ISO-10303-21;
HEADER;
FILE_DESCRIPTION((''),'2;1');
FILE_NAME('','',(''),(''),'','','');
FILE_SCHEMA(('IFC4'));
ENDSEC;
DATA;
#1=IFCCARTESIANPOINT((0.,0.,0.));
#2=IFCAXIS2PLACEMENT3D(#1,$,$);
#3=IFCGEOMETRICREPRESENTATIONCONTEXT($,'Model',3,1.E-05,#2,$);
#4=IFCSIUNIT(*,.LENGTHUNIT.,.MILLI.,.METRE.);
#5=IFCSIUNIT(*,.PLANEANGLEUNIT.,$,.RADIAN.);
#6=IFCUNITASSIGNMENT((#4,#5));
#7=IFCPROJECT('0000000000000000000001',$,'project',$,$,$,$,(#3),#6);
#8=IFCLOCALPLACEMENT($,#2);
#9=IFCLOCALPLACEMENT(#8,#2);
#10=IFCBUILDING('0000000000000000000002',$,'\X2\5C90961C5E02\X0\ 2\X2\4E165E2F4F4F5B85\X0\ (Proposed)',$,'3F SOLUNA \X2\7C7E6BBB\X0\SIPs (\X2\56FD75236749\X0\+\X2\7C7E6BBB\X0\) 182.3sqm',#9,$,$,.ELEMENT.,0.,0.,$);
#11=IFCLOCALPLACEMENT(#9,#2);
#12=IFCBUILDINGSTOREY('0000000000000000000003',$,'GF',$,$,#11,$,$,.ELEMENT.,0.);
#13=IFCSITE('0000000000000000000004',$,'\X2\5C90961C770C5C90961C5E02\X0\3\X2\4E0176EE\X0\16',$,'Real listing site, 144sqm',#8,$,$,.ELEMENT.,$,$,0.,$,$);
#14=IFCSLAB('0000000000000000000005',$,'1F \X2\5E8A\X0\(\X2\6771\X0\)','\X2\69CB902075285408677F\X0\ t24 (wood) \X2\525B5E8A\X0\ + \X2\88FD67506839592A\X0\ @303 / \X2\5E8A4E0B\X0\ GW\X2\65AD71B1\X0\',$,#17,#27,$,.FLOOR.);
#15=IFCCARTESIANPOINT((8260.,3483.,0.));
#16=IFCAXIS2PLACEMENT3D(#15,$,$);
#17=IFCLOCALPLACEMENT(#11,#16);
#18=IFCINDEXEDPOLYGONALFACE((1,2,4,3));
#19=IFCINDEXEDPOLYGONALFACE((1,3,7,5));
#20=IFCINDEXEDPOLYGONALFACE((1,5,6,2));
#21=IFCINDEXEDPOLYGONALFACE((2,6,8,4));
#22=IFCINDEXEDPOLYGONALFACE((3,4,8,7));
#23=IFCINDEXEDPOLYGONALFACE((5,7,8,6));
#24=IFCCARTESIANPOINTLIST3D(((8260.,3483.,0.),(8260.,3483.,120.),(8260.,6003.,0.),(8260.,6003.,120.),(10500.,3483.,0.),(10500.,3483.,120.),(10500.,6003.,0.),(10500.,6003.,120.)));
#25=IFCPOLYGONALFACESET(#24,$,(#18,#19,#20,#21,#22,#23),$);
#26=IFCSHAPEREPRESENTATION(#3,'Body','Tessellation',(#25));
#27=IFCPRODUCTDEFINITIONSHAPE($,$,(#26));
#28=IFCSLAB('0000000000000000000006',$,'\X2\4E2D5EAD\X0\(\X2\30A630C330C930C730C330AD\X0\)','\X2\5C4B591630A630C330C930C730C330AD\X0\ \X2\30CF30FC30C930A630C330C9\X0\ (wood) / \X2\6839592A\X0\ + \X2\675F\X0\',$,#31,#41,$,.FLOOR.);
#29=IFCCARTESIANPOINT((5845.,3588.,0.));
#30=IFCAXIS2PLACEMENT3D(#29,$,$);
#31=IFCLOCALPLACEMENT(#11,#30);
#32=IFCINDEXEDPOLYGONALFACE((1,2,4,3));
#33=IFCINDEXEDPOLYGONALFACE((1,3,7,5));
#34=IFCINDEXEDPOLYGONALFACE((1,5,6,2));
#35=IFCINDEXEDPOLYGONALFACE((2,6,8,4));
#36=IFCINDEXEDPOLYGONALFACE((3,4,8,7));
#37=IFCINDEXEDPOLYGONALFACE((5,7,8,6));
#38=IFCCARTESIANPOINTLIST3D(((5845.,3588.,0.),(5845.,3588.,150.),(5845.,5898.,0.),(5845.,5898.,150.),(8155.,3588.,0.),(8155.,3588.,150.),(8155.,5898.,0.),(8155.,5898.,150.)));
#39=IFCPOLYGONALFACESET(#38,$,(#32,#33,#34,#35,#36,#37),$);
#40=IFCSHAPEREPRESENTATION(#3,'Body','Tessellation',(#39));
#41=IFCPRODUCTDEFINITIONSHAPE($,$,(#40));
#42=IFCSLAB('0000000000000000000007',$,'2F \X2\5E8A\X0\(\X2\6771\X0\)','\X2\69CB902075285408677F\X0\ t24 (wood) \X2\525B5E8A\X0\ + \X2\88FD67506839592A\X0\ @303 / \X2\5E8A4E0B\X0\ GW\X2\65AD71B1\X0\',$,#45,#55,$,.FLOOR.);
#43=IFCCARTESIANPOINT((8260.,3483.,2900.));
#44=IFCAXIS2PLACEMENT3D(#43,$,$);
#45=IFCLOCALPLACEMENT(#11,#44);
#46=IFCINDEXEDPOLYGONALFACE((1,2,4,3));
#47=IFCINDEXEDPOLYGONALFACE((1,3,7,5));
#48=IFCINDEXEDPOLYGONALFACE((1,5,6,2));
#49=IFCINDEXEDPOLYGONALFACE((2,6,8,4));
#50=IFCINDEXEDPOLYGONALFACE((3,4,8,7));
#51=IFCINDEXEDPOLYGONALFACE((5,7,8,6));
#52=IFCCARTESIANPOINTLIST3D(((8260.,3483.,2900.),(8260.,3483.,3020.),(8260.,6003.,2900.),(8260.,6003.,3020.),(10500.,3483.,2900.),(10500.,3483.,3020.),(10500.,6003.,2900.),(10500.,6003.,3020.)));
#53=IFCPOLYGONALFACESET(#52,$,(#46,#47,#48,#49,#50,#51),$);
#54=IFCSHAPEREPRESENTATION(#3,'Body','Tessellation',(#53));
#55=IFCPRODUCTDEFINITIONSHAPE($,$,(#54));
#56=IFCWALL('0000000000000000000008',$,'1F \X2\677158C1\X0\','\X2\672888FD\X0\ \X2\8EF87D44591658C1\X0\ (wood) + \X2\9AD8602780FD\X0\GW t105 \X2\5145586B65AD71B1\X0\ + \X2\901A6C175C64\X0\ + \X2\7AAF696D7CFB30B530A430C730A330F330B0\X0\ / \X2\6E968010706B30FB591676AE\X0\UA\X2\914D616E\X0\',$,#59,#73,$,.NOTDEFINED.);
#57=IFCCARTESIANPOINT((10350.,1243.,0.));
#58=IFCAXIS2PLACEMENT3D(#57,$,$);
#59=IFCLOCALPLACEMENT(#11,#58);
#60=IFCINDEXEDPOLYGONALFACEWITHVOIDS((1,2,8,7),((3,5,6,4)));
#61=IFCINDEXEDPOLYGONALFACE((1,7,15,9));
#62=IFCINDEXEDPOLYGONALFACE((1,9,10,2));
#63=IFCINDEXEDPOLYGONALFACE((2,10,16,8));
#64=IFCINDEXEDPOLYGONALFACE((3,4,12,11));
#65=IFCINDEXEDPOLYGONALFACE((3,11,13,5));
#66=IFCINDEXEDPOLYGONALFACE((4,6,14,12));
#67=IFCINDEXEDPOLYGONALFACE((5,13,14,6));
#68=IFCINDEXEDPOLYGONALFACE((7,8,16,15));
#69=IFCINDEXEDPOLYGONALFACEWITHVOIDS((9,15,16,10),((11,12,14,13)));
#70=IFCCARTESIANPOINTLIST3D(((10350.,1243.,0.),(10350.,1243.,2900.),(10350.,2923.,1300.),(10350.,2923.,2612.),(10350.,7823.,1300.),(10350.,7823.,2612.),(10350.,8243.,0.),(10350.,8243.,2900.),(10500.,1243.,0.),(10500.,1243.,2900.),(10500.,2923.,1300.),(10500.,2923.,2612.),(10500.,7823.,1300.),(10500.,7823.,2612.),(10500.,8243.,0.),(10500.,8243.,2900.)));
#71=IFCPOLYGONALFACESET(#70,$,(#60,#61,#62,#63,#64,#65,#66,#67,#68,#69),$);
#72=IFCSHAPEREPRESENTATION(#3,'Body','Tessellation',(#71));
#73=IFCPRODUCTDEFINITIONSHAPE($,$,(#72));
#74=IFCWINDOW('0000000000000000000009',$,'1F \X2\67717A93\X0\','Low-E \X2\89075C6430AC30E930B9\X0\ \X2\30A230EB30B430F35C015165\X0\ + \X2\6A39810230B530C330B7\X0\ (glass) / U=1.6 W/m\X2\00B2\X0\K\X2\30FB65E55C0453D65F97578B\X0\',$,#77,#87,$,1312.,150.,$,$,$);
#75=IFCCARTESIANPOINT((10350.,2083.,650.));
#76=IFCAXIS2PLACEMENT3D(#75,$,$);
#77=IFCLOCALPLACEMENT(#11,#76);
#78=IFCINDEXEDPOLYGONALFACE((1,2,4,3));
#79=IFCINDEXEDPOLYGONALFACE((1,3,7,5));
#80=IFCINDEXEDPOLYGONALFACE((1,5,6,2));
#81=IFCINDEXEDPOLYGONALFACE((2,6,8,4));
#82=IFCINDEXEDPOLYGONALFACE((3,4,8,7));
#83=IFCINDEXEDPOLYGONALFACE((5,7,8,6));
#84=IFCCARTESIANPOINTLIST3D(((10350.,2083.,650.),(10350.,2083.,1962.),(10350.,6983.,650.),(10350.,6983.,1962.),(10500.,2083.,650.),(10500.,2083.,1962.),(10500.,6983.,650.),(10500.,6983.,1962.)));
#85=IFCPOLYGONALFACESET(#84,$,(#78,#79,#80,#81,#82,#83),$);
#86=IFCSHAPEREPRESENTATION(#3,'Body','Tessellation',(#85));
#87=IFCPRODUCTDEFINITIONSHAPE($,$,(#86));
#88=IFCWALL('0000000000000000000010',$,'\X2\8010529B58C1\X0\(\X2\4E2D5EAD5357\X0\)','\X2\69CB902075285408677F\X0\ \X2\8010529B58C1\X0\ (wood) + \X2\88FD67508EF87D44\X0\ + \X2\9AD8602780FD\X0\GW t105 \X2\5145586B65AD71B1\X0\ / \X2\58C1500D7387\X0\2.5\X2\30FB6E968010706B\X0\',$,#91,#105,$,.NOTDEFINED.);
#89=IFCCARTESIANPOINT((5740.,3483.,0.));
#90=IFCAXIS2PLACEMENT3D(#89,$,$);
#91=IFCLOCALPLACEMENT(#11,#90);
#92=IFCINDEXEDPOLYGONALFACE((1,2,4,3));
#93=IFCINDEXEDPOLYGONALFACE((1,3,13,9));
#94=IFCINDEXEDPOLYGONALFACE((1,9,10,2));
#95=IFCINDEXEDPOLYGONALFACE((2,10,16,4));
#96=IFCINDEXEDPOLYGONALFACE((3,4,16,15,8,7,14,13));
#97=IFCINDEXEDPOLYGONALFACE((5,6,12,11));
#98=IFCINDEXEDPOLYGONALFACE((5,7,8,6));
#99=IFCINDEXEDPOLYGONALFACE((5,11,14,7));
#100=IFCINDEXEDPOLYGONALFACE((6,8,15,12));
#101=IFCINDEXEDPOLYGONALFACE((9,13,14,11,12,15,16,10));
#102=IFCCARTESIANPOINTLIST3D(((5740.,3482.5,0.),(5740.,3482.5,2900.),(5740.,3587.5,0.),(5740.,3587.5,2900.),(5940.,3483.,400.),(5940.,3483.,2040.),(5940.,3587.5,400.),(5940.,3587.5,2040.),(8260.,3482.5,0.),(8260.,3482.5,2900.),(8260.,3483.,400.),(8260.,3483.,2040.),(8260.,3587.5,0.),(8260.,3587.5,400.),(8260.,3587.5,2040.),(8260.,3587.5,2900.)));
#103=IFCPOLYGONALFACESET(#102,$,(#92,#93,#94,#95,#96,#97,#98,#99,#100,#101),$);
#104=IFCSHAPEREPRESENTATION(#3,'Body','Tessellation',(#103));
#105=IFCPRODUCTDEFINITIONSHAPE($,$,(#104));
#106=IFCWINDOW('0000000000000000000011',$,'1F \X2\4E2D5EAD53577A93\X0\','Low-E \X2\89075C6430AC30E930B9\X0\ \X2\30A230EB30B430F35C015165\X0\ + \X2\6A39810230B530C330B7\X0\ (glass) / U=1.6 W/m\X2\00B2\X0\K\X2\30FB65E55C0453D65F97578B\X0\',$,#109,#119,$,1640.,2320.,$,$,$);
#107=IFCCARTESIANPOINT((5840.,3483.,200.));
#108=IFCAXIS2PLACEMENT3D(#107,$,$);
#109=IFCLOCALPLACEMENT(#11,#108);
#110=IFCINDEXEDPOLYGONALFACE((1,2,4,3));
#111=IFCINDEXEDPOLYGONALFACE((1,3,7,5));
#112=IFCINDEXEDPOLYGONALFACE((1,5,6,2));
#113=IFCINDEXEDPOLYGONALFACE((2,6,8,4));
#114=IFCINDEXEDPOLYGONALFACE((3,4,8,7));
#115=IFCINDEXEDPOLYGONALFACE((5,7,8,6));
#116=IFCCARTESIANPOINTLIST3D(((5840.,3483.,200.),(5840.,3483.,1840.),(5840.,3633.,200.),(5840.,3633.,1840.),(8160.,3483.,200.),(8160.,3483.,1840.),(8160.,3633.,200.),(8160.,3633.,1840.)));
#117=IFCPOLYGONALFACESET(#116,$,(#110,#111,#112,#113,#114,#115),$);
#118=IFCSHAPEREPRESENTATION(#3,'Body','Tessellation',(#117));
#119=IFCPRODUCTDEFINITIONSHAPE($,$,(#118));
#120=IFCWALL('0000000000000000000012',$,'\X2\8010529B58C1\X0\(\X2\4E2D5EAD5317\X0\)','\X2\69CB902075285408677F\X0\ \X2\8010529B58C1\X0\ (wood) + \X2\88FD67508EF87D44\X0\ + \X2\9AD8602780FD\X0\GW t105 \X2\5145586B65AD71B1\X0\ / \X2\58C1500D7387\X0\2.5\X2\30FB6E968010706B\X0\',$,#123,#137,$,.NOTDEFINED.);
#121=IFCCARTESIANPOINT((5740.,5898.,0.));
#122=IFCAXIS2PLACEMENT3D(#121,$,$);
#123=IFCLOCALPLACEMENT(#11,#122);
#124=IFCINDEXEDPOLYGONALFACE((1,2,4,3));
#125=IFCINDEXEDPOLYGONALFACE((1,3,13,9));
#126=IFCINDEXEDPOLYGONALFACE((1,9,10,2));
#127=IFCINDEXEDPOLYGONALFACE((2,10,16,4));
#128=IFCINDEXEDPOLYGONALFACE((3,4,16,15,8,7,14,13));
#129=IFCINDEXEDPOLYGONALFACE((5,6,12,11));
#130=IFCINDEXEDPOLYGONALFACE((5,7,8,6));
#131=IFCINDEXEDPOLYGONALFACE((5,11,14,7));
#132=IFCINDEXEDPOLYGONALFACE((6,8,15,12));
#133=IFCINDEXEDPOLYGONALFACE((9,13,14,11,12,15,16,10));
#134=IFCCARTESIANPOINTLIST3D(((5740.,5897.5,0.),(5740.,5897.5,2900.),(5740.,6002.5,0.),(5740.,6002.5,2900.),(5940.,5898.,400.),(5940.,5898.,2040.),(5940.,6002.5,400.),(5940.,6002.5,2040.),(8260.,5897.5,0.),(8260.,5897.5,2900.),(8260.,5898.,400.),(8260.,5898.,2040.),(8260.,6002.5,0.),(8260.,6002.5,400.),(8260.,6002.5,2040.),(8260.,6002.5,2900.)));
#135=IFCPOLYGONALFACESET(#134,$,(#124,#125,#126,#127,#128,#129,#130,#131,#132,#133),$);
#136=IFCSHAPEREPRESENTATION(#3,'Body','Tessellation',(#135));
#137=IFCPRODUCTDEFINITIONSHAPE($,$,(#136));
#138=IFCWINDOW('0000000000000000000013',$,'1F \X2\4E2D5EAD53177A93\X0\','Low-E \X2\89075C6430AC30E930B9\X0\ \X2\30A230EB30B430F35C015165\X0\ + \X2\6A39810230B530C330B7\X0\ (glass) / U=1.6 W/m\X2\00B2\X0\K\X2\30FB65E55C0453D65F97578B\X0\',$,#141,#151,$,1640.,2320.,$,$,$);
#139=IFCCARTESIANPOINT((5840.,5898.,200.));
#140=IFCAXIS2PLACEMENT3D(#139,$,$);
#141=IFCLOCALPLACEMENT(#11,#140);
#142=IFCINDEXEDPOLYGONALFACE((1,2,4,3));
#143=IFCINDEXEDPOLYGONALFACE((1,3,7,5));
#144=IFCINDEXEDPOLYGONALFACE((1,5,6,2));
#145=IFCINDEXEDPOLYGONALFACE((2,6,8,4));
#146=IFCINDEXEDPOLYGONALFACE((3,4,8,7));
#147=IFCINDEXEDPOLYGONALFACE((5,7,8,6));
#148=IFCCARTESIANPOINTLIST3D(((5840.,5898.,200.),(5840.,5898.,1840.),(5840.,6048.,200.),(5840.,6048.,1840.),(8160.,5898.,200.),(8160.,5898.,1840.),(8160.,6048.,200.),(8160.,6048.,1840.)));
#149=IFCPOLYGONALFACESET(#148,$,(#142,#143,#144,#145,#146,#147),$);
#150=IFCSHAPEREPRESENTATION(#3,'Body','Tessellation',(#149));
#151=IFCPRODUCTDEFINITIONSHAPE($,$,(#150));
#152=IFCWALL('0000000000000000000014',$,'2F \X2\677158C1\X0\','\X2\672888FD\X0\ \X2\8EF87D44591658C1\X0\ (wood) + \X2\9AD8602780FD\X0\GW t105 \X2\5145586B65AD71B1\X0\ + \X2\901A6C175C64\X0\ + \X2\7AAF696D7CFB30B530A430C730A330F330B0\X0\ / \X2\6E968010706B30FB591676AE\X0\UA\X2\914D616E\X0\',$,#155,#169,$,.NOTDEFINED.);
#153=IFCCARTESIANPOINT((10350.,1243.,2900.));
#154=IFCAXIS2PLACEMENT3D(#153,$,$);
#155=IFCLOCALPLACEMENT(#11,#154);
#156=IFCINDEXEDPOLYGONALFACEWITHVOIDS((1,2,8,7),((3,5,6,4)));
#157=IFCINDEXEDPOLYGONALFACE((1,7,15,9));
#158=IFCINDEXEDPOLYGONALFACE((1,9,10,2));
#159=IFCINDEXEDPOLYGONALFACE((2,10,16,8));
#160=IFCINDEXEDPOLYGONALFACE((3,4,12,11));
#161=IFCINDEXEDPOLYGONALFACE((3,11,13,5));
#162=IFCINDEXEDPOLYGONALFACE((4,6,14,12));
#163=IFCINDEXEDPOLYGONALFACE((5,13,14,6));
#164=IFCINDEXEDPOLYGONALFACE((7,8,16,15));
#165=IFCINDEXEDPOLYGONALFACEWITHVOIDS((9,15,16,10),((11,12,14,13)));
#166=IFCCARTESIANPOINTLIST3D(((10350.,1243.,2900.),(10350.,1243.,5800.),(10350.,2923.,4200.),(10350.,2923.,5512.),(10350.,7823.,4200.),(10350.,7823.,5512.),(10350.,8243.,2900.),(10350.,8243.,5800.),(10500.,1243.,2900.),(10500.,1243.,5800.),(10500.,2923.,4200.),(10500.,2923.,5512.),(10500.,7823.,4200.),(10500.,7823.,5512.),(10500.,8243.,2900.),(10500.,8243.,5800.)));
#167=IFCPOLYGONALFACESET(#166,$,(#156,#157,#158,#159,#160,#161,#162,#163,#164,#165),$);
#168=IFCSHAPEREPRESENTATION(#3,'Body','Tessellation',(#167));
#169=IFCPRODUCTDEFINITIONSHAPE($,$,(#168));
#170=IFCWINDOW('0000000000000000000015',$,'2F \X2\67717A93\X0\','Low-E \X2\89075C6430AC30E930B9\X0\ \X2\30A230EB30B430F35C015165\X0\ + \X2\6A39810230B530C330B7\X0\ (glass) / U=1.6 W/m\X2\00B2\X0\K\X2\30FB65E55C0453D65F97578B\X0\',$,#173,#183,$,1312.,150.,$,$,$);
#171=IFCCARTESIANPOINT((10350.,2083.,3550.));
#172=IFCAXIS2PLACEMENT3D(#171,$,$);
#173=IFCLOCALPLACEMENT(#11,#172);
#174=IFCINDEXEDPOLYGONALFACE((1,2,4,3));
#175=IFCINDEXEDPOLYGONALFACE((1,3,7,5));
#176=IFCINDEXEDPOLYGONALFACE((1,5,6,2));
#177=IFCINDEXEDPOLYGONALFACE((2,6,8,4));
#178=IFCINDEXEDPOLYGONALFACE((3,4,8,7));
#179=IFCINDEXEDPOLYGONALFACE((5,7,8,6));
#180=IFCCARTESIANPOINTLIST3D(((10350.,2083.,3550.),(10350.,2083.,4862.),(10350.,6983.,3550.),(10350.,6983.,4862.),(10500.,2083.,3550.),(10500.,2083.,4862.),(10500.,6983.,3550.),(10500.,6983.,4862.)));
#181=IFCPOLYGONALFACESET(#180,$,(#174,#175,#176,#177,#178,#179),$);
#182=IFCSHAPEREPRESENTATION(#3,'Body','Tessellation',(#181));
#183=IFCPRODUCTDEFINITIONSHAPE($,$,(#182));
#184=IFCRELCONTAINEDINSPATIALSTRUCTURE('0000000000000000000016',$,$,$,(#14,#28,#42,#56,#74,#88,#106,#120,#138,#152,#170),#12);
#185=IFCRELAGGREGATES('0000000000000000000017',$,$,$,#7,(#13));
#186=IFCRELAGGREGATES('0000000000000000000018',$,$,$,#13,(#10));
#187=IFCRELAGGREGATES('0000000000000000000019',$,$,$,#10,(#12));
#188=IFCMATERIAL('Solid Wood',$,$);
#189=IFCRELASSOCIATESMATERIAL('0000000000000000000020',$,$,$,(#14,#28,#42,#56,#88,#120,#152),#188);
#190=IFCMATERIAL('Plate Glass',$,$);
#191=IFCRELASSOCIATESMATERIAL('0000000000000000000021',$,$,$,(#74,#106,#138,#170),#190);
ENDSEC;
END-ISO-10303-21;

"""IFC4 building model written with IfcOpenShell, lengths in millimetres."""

from ifc_helpers import new_model, si_unit, frame, frame_2d, origin, place, context, project, spatial, rectangle, extrude, material, element, fill, save


model = new_model("IFC4")

# Units and contexts
model_context = context("Model", 3, precision=1e-05, world=origin())
ifc_project = project(units=[si_unit("LENGTHUNIT", "METRE", prefix="MILLI"), si_unit("PLANEANGLEUNIT", "RADIAN")], contexts=[model_context])

# Site, building, storey
site_placement = place(None, origin())
site = spatial("IfcSite", under=ifc_project, at=site_placement, Name="岐阜県岐阜市3丁目16", ObjectType="Real listing site, 144sqm", CompositionType="ELEMENT", RefElevation=0.0)
building_placement = place(site_placement, origin())
building = spatial("IfcBuilding", under=site, at=building_placement, Name="岐阜市 2世帯住宅 (Proposed)", ObjectType="3F SOLUNA 籾殻SIPs (国産杉+籾殻) 182.3sqm", CompositionType="ELEMENT", ElevationOfRefHeight=0.0, ElevationOfTerrain=0.0)
storey_placement = place(building_placement, origin())
storey = spatial("IfcBuildingStorey", under=building, at=storey_placement, Name="GF", CompositionType="ELEMENT", Elevation=0.0)

# Slabs
ifc_material_1 = material(Name="Solid Wood")
slab_1_placement = place(storey_placement, frame((8260.0, 3483.0, 0.0)))
element("IfcSlab", 1, at=slab_1_placement, inside=storey, material=ifc_material_1, Name="1F 床(東)", Description="構造用合板 t24 (wood) 剛床 + 製材根太 @303 / 床下 GW断熱", PredefinedType="FLOOR", context=model_context, shape_type="SweptSolid", body=[
    extrude(rectangle(XDim=2240.0, YDim=2520.0, at=frame_2d((1120.0, 1260.0))), frame((8260.0, 3483.0, 0.0)), (0.0, 0.0, 1.0), 120.0),
])
slab_2_placement = place(storey_placement, frame((5845.0, 3588.0, 0.0)))
element("IfcSlab", 2, at=slab_2_placement, inside=storey, material=ifc_material_1, Name="中庭(ウッドデッキ)", Description="屋外ウッドデッキ ハードウッド (wood) / 根太 + 束", PredefinedType="FLOOR", context=model_context, shape_type="SweptSolid", body=[
    extrude(rectangle(XDim=2310.0, YDim=2310.0, at=frame_2d((1155.0, 1155.0))), frame((5845.0, 3588.0, 0.0)), (0.0, 0.0, 1.0), 150.0),
])
slab_3_placement = place(storey_placement, frame((8260.0, 3483.0, 2900.0)))
element("IfcSlab", 3, at=slab_3_placement, inside=storey, material=ifc_material_1, Name="2F 床(東)", Description="構造用合板 t24 (wood) 剛床 + 製材根太 @303 / 床下 GW断熱", PredefinedType="FLOOR", context=model_context, shape_type="SweptSolid", body=[
    extrude(rectangle(XDim=2240.0, YDim=2520.0, at=frame_2d((1120.0, 1260.0))), frame((8260.0, 3483.0, 2900.0)), (0.0, 0.0, 1.0), 120.0),
])

# Walls, openings, windows
wall_1_placement = place(storey_placement, frame((10350.0, 1243.0, 0.0)))
wall_1 = element("IfcWall", 4, at=wall_1_placement, inside=storey, material=ifc_material_1, Name="1F 東壁", Description="木製 軸組外壁 (wood) + 高性能GW t105 充填断熱 + 通気層 + 窯業系サイディング / 準耐火・外皮UA配慮", PredefinedType="NOTDEFINED", context=model_context, shape_type="SweptSolid", body=[
    extrude(rectangle(XDim=150.0, YDim=7000.0, at=frame_2d((75.0, 3500.0))), frame((10350.0, 1243.0, 0.0)), (0.0, 0.0, 1.0), 2900.0),
])
opening_1_placement = place(storey_placement, frame((10350.0, 2083.0, 650.0)))
opening_1 = element("IfcOpeningElement", 5, at=opening_1_placement, cuts=wall_1, PredefinedType="NOTDEFINED", context=model_context, shape_type="SweptSolid", body=[
    extrude(rectangle(XDim=150.0, YDim=4900.0, at=frame_2d((75.0, 2450.0))), frame((10350.0, 2083.0, 650.0)), (0.0, 0.0, 1.0), 1312.0),
])
ifc_material_2 = material(Name="Plate Glass")
window_1_placement = place(storey_placement, frame((10350.0, 2083.0, 650.0)))
window_1 = element("IfcWindow", 6, at=window_1_placement, inside=storey, material=ifc_material_2, Name="1F 東窓", Description="Low-E 複層ガラス アルゴン封入 + 樹脂サッシ (glass) / U=1.6 W/m²K・日射取得型", OverallHeight=1312.0, OverallWidth=150.0, context=model_context, shape_type="SweptSolid", body=[
    extrude(rectangle(XDim=150.0, YDim=4900.0, at=frame_2d((75.0, 2450.0))), frame((10350.0, 2083.0, 650.0)), (0.0, 0.0, 1.0), 1312.0),
])
fill(opening_1, window_1)
wall_2_placement = place(storey_placement, frame((5740.0, 3483.0, 0.0)))
wall_2 = element("IfcWall", 7, at=wall_2_placement, inside=storey, material=ifc_material_1, Name="耐力壁(中庭南)", Description="構造用合板 耐力壁 (wood) + 製材軸組 + 高性能GW t105 充填断熱 / 壁倍率2.5・準耐火", PredefinedType="NOTDEFINED", context=model_context, shape_type="SweptSolid", body=[
    extrude(rectangle(XDim=2520.0, YDim=105.0, at=frame_2d((1260.0, 52.0))), frame((5740.0, 3483.0, 0.0)), (0.0, 0.0, 1.0), 2900.0),
])
opening_2_placement = place(storey_placement, frame((5840.0, 3483.0, 200.0)))
opening_2 = element("IfcOpeningElement", 8, at=opening_2_placement, cuts=wall_2, PredefinedType="NOTDEFINED", context=model_context, shape_type="SweptSolid", body=[
    extrude(rectangle(XDim=2320.0, YDim=150.0, at=frame_2d((1160.0, 75.0))), frame((5840.0, 3483.0, 200.0)), (0.0, 0.0, 1.0), 1640.0),
])
window_2_placement = place(storey_placement, frame((5840.0, 3483.0, 200.0)))
window_2 = element("IfcWindow", 9, at=window_2_placement, inside=storey, material=ifc_material_2, Name="1F 中庭南窓", Description="Low-E 複層ガラス アルゴン封入 + 樹脂サッシ (glass) / U=1.6 W/m²K・日射取得型", OverallHeight=1640.0, OverallWidth=2320.0, context=model_context, shape_type="SweptSolid", body=[
    extrude(rectangle(XDim=2320.0, YDim=150.0, at=frame_2d((1160.0, 75.0))), frame((5840.0, 3483.0, 200.0)), (0.0, 0.0, 1.0), 1640.0),
])
fill(opening_2, window_2)
wall_3_placement = place(storey_placement, frame((5740.0, 5898.0, 0.0)))
wall_3 = element("IfcWall", 10, at=wall_3_placement, inside=storey, material=ifc_material_1, Name="耐力壁(中庭北)", Description="構造用合板 耐力壁 (wood) + 製材軸組 + 高性能GW t105 充填断熱 / 壁倍率2.5・準耐火", PredefinedType="NOTDEFINED", context=model_context, shape_type="SweptSolid", body=[
    extrude(rectangle(XDim=2520.0, YDim=105.0, at=frame_2d((1260.0, 52.0))), frame((5740.0, 5898.0, 0.0)), (0.0, 0.0, 1.0), 2900.0),
])
opening_3_placement = place(storey_placement, frame((5840.0, 5898.0, 200.0)))
opening_3 = element("IfcOpeningElement", 11, at=opening_3_placement, cuts=wall_3, PredefinedType="NOTDEFINED", context=model_context, shape_type="SweptSolid", body=[
    extrude(rectangle(XDim=2320.0, YDim=150.0, at=frame_2d((1160.0, 75.0))), frame((5840.0, 5898.0, 200.0)), (0.0, 0.0, 1.0), 1640.0),
])
window_3_placement = place(storey_placement, frame((5840.0, 5898.0, 200.0)))
window_3 = element("IfcWindow", 12, at=window_3_placement, inside=storey, material=ifc_material_2, Name="1F 中庭北窓", Description="Low-E 複層ガラス アルゴン封入 + 樹脂サッシ (glass) / U=1.6 W/m²K・日射取得型", OverallHeight=1640.0, OverallWidth=2320.0, context=model_context, shape_type="SweptSolid", body=[
    extrude(rectangle(XDim=2320.0, YDim=150.0, at=frame_2d((1160.0, 75.0))), frame((5840.0, 5898.0, 200.0)), (0.0, 0.0, 1.0), 1640.0),
])
fill(opening_3, window_3)

# Wall, opening, window
wall_4_placement = place(storey_placement, frame((10350.0, 1243.0, 2900.0)))
wall_4 = element("IfcWall", 13, at=wall_4_placement, inside=storey, material=ifc_material_1, Name="2F 東壁", Description="木製 軸組外壁 (wood) + 高性能GW t105 充填断熱 + 通気層 + 窯業系サイディング / 準耐火・外皮UA配慮", PredefinedType="NOTDEFINED", context=model_context, shape_type="SweptSolid", body=[
    extrude(rectangle(XDim=150.0, YDim=7000.0, at=frame_2d((75.0, 3500.0))), frame((10350.0, 1243.0, 2900.0)), (0.0, 0.0, 1.0), 2900.0),
])
opening_4_placement = place(storey_placement, frame((10350.0, 2083.0, 3550.0)))
opening_4 = element("IfcOpeningElement", 14, at=opening_4_placement, cuts=wall_4, PredefinedType="NOTDEFINED", context=model_context, shape_type="SweptSolid", body=[
    extrude(rectangle(XDim=150.0, YDim=4900.0, at=frame_2d((75.0, 2450.0))), frame((10350.0, 2083.0, 3550.0)), (0.0, 0.0, 1.0), 1312.0),
])
window_4_placement = place(storey_placement, frame((10350.0, 2083.0, 3550.0)))
window_4 = element("IfcWindow", 15, at=window_4_placement, inside=storey, material=ifc_material_2, Name="2F 東窓", Description="Low-E 複層ガラス アルゴン封入 + 樹脂サッシ (glass) / U=1.6 W/m²K・日射取得型", OverallHeight=1312.0, OverallWidth=150.0, context=model_context, shape_type="SweptSolid", body=[
    extrude(rectangle(XDim=150.0, YDim=4900.0, at=frame_2d((75.0, 2450.0))), frame((10350.0, 2083.0, 3550.0)), (0.0, 0.0, 1.0), 1312.0),
])
fill(opening_4, window_4)

save(model, "model.ifc")
